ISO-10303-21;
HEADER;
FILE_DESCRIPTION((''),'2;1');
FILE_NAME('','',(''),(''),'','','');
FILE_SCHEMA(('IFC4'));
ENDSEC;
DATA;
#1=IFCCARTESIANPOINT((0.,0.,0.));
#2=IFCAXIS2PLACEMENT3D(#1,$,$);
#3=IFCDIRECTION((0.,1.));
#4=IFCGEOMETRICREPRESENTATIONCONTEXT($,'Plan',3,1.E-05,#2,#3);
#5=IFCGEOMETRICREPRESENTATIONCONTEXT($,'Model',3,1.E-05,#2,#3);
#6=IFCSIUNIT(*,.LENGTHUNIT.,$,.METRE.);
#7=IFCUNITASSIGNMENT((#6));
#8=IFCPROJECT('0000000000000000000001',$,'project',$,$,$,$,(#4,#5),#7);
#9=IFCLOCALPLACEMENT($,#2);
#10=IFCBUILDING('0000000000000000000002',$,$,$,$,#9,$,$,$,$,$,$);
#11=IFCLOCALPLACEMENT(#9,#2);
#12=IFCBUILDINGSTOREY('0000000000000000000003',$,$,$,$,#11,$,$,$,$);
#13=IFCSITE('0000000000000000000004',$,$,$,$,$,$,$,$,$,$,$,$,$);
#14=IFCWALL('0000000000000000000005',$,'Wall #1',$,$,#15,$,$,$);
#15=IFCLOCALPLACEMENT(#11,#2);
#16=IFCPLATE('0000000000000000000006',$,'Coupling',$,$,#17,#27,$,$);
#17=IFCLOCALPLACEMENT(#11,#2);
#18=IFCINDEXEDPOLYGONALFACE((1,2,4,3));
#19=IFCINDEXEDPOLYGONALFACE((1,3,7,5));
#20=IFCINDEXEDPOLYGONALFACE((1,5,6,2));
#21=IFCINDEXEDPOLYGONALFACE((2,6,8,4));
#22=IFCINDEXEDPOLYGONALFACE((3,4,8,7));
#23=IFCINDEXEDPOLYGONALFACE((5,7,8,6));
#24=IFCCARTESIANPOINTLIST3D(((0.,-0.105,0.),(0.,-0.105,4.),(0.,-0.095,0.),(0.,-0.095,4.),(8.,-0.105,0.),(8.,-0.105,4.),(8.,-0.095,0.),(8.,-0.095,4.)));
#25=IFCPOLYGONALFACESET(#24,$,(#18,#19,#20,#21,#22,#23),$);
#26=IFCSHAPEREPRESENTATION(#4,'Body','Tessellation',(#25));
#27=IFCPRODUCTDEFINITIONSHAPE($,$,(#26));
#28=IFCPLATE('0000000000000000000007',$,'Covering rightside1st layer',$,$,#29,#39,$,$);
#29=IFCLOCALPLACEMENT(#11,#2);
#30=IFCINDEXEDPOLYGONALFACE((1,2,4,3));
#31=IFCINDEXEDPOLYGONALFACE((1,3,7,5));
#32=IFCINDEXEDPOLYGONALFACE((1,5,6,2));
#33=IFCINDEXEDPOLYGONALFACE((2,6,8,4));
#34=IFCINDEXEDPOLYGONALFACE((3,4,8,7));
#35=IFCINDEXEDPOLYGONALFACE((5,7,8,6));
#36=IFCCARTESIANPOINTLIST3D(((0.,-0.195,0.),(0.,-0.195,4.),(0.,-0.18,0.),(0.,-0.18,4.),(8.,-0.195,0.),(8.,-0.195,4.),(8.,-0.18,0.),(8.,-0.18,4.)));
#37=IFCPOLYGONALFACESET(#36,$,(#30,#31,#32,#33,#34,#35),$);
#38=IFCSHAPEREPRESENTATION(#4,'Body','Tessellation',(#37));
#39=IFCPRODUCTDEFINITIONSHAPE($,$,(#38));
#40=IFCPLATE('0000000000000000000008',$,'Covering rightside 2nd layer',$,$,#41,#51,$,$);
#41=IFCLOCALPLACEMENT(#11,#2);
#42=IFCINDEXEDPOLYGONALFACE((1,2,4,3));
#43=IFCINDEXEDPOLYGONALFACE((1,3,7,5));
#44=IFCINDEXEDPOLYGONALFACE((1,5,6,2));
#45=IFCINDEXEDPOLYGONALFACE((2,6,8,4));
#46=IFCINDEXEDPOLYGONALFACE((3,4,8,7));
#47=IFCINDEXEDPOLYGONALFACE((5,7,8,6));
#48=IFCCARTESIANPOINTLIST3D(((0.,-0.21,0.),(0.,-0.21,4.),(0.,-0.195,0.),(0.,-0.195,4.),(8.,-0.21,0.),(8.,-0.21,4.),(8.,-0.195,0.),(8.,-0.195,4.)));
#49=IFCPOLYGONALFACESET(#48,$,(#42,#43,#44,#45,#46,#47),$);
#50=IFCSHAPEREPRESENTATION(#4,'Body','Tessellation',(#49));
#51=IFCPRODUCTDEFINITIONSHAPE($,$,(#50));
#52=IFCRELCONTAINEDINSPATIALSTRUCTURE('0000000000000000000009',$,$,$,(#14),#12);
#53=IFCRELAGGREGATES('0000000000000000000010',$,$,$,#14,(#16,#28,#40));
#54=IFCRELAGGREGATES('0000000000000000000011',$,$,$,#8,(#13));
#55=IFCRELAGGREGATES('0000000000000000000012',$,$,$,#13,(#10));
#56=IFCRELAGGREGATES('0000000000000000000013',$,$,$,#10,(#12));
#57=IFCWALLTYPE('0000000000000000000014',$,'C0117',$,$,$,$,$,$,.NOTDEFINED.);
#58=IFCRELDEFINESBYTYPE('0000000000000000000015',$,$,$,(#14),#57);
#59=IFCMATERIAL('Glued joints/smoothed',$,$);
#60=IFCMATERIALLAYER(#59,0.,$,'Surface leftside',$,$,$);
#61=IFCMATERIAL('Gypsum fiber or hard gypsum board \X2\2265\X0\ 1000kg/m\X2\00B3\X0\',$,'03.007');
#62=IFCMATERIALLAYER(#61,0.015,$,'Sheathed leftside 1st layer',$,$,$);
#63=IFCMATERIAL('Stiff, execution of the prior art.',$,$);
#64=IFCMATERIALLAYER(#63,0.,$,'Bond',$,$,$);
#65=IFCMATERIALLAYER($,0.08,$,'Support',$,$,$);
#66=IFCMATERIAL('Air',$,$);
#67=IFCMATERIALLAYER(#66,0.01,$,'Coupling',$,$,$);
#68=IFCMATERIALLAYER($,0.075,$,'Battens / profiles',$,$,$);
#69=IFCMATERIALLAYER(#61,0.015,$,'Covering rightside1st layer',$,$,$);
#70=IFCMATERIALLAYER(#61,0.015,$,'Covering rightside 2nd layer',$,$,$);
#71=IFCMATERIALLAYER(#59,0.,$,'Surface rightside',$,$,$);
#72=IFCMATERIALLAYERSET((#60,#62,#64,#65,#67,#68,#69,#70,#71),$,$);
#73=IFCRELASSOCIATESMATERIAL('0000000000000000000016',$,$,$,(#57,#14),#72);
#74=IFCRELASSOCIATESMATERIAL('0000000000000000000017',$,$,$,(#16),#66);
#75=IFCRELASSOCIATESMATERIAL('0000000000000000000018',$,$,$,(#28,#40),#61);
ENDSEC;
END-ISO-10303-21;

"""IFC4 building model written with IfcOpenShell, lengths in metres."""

from ifc_helpers import new_model, si_unit, direction, frame, frame_2d, origin, place, context, project, spatial, rectangle, extrude, material, layer, layer_set, type_object, element, aggregate, save


model = new_model("IFC4")

# Units and contexts
plan_context = context("Plan", 3, precision=1e-05, world=origin(), true_north=direction((0.0, 1.0)))
model_context = context("Model", 3, precision=1e-05, world=origin(), true_north=direction((0.0, 1.0)))
ifc_project = project(units=[si_unit("LENGTHUNIT", "METRE")], contexts=[plan_context, model_context])

# Site, building, storey
site = spatial("IfcSite", under=ifc_project)
building_placement = place(None, origin())
building = spatial("IfcBuilding", under=site, at=building_placement)
storey_placement = place(building_placement, origin())
storey = spatial("IfcBuildingStorey", under=building, at=storey_placement)

# Wall, plates
ifc_material_1 = material(Name="Glued joints/smoothed")
ifc_layer_1 = layer(ifc_material_1, 0.0, Name="Surface leftside")
ifc_material_2 = material(Name="Gypsum fiber or hard gypsum board ≥ 1000kg/m³", Category="03.007")
ifc_layer_2 = layer(ifc_material_2, 0.015, Name="Sheathed leftside 1st layer")
ifc_material_3 = material(Name="Stiff, execution of the prior art.")
ifc_layer_3 = layer(ifc_material_3, 0.0, Name="Bond")
ifc_layer_4 = layer(None, 0.08, Name="Support")
ifc_material_4 = material(Name="Air")
ifc_layer_5 = layer(ifc_material_4, 0.01, Name="Coupling")
ifc_layer_6 = layer(None, 0.075, Name="Battens / profiles")
ifc_layer_7 = layer(ifc_material_2, 0.015, Name="Covering rightside1st layer")
ifc_layer_8 = layer(ifc_material_2, 0.015, Name="Covering rightside 2nd layer")
ifc_layer_9 = layer(ifc_material_1, 0.0, Name="Surface rightside")
ifc_layer_set = layer_set([ifc_layer_1, ifc_layer_2, ifc_layer_3, ifc_layer_4, ifc_layer_5, ifc_layer_6, ifc_layer_7, ifc_layer_8, ifc_layer_9])
wall_type = type_object("IfcWallType", Name="C0117", PredefinedType="NOTDEFINED", material=ifc_layer_set)
wall_placement = place(None, frame((0.0, 0.0, 0.0), z_axis=(0.0, -1.0, 0.0), x_axis=(1.0, 0.0, 0.0)))
wall = element("IfcWall", 1, at=wall_placement, inside=storey, type_object=wall_type, material=ifc_layer_set, Name="Wall #1")
plate_1_placement = place(wall_placement, origin())
plate_1 = element("IfcPlate", 2, at=plate_1_placement, material=ifc_material_4, Name="Coupling", context=plan_context, shape_type="SweptSolid", body=[
    extrude(rectangle(XDim=8.0, YDim=4.0, at=frame_2d((4.0, 2.0), x_axis=(1.0, 0.0))), frame((0.0, 0.0, 0.095), z_axis=(0.0, 0.0, 1.0), x_axis=(1.0, 0.0, 0.0)), (0.0, 0.0, 1.0), 0.01),
])
plate_2_placement = place(wall_placement, origin())
plate_2 = element("IfcPlate", 3, at=plate_2_placement, material=ifc_material_2, Name="Covering rightside1st layer", context=plan_context, shape_type="SweptSolid", body=[
    extrude(rectangle(XDim=8.0, YDim=4.0, at=frame_2d((4.0, 2.0), x_axis=(1.0, 0.0))), frame((0.0, 0.0, 0.18), z_axis=(0.0, 0.0, 1.0), x_axis=(1.0, 0.0, 0.0)), (0.0, 0.0, 1.0), 0.015),
])
plate_3_placement = place(wall_placement, origin())
plate_3 = element("IfcPlate", 4, at=plate_3_placement, material=ifc_material_2, Name="Covering rightside 2nd layer", context=plan_context, shape_type="SweptSolid", body=[
    extrude(rectangle(XDim=8.0, YDim=4.0, at=frame_2d((4.0, 2.0), x_axis=(1.0, 0.0))), frame((0.0, 0.0, 0.195), z_axis=(0.0, 0.0, 1.0), x_axis=(1.0, 0.0, 0.0)), (0.0, 0.0, 1.0), 0.015),
])
aggregate(wall, [plate_1, plate_2, plate_3])

save(model, "model.ifc")
